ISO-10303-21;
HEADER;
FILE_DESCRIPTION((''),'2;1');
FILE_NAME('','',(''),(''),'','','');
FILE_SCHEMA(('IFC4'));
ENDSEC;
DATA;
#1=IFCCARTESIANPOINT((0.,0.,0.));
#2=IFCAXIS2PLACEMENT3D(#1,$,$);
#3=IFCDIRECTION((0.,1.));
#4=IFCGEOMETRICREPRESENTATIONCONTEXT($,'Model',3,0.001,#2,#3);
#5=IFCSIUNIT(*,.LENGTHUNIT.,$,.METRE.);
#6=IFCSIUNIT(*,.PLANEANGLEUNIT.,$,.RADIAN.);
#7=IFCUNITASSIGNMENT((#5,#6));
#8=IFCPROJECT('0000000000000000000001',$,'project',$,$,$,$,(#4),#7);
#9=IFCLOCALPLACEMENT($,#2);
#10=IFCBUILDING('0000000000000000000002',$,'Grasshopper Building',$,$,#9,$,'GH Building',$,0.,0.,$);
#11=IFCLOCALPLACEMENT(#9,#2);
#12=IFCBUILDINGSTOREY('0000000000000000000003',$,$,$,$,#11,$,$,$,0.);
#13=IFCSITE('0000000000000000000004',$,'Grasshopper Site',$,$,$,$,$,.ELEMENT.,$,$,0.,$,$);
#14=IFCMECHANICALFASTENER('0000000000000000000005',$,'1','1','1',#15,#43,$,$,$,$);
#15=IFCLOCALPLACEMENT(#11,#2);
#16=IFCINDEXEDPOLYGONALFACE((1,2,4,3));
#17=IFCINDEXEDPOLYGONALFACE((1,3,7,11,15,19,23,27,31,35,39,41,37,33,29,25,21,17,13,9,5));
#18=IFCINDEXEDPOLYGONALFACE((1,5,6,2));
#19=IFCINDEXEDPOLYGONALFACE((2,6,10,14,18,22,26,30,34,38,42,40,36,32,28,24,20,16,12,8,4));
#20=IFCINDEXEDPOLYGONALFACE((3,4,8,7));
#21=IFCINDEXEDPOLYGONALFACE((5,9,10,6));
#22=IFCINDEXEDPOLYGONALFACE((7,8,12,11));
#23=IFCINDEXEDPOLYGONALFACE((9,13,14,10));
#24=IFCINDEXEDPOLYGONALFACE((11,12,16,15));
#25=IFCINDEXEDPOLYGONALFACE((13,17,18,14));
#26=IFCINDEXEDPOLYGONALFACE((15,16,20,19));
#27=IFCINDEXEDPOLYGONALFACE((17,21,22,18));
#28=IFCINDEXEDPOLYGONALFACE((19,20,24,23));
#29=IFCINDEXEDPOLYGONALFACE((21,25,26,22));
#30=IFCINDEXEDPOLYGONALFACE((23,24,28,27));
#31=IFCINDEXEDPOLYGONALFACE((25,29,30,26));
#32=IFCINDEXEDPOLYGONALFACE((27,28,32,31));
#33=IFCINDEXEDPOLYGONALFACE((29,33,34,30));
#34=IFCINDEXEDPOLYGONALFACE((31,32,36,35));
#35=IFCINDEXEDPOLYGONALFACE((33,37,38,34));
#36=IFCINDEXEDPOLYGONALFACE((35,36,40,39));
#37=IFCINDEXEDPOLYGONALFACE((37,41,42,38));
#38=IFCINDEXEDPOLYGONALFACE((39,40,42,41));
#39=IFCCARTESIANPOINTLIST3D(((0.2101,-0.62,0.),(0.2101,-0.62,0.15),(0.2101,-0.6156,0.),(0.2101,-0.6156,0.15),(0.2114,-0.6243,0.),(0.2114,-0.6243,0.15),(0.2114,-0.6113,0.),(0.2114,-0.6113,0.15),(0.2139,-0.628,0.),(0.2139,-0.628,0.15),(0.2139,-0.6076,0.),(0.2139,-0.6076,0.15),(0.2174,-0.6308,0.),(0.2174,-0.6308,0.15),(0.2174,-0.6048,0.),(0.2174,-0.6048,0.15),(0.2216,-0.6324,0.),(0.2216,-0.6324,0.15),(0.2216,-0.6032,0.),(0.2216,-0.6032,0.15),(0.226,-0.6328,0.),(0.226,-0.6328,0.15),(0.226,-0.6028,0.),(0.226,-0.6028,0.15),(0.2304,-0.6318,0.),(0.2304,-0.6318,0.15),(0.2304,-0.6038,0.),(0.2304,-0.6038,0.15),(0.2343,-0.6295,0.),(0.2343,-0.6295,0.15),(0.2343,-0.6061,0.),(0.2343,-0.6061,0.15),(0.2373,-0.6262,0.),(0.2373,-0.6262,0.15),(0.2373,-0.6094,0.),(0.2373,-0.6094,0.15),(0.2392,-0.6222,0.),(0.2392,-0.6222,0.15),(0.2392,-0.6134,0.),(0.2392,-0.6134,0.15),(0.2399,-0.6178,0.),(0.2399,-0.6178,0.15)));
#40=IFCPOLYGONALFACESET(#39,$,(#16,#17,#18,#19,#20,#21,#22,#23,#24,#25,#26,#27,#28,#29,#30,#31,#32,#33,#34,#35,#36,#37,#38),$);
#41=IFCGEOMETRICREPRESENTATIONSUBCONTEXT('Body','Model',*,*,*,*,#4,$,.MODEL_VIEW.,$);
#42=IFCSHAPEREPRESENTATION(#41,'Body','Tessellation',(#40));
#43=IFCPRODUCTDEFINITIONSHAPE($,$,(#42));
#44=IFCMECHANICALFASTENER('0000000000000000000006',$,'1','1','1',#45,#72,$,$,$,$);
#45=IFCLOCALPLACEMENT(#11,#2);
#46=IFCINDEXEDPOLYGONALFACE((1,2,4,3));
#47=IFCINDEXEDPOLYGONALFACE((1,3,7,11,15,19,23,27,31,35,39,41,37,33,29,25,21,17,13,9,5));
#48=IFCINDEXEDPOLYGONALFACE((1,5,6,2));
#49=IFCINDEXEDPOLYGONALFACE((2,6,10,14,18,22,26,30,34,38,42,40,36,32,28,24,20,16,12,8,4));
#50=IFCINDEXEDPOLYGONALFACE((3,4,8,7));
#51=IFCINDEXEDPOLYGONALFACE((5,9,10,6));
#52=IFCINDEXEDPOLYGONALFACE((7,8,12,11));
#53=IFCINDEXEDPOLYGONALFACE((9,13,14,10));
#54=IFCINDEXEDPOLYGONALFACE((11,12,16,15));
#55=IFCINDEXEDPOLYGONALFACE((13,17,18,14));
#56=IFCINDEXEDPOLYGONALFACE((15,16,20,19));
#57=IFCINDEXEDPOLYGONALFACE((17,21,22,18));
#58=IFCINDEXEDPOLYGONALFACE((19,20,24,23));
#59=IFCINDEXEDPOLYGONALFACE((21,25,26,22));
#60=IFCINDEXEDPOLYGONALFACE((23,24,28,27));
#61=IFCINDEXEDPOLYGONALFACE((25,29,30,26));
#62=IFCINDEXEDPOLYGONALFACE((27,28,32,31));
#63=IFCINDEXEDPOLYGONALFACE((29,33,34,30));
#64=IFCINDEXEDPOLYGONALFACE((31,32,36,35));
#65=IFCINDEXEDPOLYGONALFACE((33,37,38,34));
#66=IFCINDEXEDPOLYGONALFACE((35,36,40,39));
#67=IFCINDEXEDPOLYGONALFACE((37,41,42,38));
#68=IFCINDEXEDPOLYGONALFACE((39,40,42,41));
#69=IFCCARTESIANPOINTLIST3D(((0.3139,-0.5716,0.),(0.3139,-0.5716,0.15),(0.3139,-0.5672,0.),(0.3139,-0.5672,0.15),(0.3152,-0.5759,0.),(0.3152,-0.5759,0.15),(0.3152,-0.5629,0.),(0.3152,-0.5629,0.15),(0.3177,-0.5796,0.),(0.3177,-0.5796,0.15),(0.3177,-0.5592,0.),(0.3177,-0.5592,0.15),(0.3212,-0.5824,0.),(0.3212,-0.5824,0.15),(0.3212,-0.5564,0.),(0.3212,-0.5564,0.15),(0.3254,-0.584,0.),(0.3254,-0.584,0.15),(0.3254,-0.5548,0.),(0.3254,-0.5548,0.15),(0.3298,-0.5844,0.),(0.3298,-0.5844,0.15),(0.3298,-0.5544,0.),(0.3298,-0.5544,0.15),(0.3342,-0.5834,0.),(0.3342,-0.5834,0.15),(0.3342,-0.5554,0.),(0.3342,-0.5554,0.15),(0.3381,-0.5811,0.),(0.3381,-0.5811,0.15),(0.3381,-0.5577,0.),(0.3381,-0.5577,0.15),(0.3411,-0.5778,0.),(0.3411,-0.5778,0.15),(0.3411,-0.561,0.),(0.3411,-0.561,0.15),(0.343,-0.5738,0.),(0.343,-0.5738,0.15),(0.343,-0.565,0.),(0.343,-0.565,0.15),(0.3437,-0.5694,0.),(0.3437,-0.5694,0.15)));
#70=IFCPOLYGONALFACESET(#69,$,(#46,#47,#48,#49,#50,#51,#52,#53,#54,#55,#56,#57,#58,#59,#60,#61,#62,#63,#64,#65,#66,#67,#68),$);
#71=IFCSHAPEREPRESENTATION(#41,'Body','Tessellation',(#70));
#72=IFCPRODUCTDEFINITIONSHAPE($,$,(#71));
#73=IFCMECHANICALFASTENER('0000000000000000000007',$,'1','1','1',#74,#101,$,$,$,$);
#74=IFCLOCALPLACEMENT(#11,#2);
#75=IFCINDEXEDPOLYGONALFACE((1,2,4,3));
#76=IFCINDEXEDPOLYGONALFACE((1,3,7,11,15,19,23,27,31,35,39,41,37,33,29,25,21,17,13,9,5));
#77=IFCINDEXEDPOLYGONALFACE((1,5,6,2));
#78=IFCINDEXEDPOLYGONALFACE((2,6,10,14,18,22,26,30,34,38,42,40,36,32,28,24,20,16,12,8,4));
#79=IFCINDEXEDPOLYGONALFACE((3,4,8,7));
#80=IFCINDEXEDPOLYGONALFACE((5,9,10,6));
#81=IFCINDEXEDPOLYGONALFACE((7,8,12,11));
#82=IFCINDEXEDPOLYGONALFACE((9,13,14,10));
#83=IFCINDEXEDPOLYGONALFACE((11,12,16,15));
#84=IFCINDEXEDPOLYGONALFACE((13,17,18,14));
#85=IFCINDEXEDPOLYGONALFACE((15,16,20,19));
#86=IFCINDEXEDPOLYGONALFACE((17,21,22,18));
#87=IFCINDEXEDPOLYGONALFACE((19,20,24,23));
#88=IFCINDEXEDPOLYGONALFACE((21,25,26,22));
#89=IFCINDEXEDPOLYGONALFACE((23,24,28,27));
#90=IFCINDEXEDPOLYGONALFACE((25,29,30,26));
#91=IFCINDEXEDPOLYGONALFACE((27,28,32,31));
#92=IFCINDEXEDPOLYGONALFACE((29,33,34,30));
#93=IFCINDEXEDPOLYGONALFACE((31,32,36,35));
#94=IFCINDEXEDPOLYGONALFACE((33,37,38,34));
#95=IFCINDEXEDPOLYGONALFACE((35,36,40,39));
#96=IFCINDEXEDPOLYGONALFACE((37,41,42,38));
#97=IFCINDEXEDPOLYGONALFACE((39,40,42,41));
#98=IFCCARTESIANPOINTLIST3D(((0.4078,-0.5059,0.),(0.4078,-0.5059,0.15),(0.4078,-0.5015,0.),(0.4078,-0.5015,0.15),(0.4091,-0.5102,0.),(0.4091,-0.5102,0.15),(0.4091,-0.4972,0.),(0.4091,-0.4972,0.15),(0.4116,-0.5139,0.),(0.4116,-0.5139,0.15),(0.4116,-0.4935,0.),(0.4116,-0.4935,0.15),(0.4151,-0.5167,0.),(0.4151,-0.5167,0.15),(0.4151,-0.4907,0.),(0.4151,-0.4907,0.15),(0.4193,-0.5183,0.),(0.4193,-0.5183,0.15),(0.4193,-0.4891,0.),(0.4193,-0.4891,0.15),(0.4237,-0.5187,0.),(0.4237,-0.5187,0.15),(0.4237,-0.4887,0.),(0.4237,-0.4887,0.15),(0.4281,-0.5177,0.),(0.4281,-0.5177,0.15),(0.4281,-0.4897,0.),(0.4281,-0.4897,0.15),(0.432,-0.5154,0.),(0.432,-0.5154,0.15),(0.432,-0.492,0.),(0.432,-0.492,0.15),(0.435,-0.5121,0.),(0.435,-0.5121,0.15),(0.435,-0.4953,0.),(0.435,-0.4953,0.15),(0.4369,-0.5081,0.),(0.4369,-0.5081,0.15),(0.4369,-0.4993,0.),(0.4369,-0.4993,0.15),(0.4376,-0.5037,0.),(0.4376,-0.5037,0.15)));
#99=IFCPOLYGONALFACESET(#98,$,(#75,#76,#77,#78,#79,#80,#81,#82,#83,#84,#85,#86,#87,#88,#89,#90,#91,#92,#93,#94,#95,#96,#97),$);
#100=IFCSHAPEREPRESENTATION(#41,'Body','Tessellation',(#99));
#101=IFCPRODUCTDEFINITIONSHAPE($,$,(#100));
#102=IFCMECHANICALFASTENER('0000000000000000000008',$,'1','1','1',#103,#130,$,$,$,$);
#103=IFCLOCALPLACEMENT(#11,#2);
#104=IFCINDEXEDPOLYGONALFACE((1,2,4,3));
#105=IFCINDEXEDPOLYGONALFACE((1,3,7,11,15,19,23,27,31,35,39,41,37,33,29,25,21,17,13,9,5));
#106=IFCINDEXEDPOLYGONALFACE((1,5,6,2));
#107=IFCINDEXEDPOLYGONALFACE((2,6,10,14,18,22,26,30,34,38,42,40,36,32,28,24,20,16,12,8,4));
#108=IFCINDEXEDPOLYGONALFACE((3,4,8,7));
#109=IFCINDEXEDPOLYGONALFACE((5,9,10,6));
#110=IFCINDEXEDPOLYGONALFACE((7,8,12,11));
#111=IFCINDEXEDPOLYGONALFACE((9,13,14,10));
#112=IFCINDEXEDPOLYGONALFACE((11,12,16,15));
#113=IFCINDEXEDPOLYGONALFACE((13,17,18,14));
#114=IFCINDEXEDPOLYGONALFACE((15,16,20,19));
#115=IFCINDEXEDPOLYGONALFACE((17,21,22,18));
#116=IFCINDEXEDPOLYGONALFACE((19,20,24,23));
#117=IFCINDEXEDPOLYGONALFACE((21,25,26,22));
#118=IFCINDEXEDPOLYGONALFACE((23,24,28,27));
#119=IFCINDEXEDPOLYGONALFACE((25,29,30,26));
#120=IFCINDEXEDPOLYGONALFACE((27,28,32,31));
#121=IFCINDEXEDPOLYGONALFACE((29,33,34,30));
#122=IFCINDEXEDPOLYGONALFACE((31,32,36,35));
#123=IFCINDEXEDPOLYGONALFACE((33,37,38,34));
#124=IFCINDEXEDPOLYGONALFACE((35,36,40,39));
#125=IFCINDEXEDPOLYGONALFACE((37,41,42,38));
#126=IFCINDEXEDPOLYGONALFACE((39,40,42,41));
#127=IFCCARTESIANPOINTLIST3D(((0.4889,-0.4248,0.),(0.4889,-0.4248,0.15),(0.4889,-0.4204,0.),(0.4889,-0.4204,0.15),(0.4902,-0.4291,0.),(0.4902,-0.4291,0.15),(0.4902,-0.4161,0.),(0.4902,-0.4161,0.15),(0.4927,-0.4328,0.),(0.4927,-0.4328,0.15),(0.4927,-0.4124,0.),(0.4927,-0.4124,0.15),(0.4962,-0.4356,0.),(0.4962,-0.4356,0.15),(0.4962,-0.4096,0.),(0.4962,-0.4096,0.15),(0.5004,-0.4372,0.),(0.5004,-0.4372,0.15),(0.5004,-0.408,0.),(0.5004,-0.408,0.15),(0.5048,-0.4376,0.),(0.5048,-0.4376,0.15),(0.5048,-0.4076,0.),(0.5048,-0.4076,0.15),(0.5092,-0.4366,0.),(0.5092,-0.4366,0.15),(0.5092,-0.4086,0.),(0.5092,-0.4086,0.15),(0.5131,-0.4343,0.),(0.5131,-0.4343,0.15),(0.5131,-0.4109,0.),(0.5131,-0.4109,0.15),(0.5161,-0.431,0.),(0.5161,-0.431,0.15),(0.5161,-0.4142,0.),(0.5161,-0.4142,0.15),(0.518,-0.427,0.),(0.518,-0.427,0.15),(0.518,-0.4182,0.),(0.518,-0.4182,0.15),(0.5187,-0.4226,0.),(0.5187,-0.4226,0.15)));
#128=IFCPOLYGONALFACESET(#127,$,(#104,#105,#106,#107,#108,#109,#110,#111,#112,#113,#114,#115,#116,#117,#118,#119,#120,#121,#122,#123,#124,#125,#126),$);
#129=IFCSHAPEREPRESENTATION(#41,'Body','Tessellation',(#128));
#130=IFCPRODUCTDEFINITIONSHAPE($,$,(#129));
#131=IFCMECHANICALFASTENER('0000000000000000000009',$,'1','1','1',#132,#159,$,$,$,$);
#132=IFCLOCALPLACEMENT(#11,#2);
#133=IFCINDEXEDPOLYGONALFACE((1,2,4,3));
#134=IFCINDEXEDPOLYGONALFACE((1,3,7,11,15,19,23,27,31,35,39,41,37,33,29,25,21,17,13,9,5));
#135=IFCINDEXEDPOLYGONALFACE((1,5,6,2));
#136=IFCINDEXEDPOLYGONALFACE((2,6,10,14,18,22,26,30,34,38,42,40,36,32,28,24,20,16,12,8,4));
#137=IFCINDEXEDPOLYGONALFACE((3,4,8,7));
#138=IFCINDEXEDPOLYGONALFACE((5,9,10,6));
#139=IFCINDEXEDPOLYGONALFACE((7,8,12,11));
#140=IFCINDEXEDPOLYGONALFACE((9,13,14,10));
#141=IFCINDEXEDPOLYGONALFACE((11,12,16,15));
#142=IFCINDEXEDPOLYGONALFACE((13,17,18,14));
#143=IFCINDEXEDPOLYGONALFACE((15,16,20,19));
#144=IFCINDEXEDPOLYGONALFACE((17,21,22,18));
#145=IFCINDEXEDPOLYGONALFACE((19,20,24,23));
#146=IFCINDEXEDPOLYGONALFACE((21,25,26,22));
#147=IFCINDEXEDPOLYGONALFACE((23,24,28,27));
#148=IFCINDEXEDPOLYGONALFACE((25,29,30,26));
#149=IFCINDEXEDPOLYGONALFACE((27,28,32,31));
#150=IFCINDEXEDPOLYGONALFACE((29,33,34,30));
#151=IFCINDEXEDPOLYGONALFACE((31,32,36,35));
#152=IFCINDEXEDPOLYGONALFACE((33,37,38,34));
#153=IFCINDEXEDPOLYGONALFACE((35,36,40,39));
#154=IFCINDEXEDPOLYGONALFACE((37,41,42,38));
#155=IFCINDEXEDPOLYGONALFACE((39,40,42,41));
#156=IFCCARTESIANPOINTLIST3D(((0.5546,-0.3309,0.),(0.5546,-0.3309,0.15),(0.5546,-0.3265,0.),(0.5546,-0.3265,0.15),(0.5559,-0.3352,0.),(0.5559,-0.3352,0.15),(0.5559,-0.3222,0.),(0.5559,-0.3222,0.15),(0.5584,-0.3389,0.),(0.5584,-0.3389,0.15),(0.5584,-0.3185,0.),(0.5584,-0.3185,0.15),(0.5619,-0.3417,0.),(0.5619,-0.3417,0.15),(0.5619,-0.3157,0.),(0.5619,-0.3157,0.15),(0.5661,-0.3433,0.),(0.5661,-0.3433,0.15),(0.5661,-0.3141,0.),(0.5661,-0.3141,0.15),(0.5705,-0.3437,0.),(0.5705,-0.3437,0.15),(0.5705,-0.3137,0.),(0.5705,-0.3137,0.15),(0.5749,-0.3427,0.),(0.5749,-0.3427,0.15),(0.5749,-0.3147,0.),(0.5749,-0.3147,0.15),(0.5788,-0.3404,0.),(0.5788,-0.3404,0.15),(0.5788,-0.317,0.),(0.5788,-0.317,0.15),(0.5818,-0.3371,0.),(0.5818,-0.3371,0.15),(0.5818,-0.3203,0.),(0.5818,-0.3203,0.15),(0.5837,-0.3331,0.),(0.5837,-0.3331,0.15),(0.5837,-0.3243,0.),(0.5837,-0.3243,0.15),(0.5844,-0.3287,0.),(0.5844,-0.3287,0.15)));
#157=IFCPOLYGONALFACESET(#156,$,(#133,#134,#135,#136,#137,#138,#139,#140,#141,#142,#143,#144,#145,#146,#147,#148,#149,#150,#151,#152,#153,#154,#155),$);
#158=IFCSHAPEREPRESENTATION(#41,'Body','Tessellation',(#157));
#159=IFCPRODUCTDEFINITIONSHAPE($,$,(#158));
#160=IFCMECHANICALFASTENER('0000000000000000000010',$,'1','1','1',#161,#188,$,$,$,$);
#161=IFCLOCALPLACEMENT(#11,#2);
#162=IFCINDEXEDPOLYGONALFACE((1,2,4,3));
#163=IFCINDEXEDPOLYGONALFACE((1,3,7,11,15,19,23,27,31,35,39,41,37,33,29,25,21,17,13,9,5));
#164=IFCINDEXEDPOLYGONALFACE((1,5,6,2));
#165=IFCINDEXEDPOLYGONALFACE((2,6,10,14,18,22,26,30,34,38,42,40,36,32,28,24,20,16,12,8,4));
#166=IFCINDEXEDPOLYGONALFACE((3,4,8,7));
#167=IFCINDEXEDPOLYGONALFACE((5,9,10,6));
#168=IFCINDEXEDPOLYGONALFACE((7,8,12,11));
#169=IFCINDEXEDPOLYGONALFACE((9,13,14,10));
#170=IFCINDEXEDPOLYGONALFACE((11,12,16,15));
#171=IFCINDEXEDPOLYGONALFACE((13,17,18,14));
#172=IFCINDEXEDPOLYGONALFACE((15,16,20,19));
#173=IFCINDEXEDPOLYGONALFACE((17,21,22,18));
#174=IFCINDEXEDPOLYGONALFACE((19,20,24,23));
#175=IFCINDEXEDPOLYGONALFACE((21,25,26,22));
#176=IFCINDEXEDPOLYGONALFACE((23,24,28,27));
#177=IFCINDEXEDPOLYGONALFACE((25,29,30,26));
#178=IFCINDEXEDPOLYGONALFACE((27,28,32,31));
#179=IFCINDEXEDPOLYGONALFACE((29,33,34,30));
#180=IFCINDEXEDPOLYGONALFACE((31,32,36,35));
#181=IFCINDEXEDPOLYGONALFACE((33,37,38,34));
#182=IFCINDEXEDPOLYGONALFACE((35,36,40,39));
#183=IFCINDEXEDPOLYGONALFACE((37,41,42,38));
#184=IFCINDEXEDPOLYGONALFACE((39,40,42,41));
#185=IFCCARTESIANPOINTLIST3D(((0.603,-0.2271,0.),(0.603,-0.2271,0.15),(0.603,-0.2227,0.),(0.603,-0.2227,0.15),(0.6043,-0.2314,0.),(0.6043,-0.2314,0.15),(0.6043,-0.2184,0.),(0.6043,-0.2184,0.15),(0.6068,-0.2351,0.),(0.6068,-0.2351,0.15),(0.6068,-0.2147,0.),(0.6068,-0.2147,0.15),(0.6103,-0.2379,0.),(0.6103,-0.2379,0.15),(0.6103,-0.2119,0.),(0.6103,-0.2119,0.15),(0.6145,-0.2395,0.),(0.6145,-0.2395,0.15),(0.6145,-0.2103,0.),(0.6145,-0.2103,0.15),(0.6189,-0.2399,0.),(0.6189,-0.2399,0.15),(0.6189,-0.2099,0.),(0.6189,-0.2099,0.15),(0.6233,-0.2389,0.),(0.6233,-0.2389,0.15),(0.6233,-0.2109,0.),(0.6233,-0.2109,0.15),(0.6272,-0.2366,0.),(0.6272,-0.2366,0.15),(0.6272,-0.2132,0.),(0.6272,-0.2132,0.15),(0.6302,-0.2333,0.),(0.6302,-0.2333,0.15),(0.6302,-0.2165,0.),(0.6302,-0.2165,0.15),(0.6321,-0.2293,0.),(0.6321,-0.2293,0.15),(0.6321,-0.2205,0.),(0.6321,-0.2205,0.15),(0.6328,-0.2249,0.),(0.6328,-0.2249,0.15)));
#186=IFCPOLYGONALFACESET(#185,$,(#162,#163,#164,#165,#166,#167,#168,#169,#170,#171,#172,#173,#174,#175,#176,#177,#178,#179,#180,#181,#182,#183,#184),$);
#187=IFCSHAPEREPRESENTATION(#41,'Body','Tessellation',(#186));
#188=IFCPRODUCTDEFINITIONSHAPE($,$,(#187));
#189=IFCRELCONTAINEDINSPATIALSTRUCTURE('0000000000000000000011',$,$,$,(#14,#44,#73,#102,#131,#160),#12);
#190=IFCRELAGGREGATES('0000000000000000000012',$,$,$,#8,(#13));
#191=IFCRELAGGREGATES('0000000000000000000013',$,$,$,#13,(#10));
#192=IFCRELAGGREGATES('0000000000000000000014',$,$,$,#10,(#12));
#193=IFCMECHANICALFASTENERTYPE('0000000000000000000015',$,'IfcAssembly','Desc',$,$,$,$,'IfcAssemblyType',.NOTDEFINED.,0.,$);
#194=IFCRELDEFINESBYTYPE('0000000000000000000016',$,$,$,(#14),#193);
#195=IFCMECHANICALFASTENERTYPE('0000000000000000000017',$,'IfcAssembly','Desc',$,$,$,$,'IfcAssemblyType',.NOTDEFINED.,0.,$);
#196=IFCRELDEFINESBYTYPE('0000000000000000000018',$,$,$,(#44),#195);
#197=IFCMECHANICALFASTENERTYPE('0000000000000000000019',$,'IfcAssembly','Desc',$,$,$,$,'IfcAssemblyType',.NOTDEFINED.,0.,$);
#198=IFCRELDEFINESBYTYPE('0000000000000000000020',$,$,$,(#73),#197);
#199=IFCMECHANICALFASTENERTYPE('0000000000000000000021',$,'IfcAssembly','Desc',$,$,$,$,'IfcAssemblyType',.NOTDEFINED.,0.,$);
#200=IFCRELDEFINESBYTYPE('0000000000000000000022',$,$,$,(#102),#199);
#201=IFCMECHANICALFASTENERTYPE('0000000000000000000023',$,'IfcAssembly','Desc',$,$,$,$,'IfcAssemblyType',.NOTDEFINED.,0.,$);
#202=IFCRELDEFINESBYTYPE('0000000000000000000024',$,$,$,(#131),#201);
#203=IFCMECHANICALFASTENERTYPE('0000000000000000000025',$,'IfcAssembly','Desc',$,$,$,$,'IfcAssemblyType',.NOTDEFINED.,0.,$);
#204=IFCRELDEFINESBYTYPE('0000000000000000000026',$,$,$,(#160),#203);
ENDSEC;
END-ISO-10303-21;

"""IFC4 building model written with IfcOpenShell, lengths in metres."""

from ifc_helpers import new_model, si_unit, direction, frame, origin, place, context, subcontext, project, spatial, circle, extrude, source, transform, mapped, type_object, type_shapes, element, save


model = new_model("IFC4")

# Units and contexts
model_context = context("Model", 3, precision=0.001, world=origin(), true_north=direction((0.0, 1.0)))
body_context = subcontext(model_context, "Body", "Model", "MODEL_VIEW")
ifc_project = project(units=[si_unit("LENGTHUNIT", "METRE"), si_unit("PLANEANGLEUNIT", "RADIAN")], contexts=[model_context])

# Site, building, storey
site = spatial("IfcSite", under=ifc_project, Name="Grasshopper Site", CompositionType="ELEMENT", RefElevation=0.0)
building_placement = place(None, origin())
building = spatial("IfcBuilding", under=site, at=building_placement, Name="Grasshopper Building", LongName="GH Building", ElevationOfRefHeight=0.0, ElevationOfTerrain=0.0)
storey_placement = place(building_placement, origin())
storey = spatial("IfcBuildingStorey", under=building, at=storey_placement, Elevation=0.0)

# Mechanical fasteners
mechanical_fastener_type_1 = type_object("IfcMechanicalFastenerType", Name="IfcAssembly", Description="Desc", ElementType="IfcAssemblyType", NominalDiameter=0.0)
shared_shape_1 = source(origin(), body_context, "Body", "SweptSolid", [
    extrude(circle(Radius=0.015), frame((0.2249, -0.6178, 0.0)), (0.0, 0.0, 1.0), 0.15),
])
type_shapes(mechanical_fastener_type_1, [shared_shape_1])
mechanical_fastener_1_placement = place(storey_placement, origin())
element("IfcMechanicalFastener", 1, at=mechanical_fastener_1_placement, inside=storey, type_object=mechanical_fastener_type_1, Name="1", Description="1", ObjectType="1", context=body_context, shape_type="MappedRepresentation", body=[
    mapped(shared_shape_1, transform((0.0, 0.0, 0.0), scale=1.0)),
])
mechanical_fastener_type_2 = type_object("IfcMechanicalFastenerType", Name="IfcAssembly", Description="Desc", ElementType="IfcAssemblyType", NominalDiameter=0.0)
shared_shape_2 = source(origin(), body_context, "Body", "SweptSolid", [
    extrude(circle(Radius=0.015), frame((0.3287, -0.5694, 0.0)), (0.0, 0.0, 1.0), 0.15),
])
type_shapes(mechanical_fastener_type_2, [shared_shape_2])
mechanical_fastener_2_placement = place(storey_placement, origin())
element("IfcMechanicalFastener", 2, at=mechanical_fastener_2_placement, inside=storey, type_object=mechanical_fastener_type_2, Name="1", Description="1", ObjectType="1", context=body_context, shape_type="MappedRepresentation", body=[
    mapped(shared_shape_2, transform((0.0, 0.0, 0.0), scale=1.0)),
])
mechanical_fastener_type_3 = type_object("IfcMechanicalFastenerType", Name="IfcAssembly", Description="Desc", ElementType="IfcAssemblyType", NominalDiameter=0.0)
shared_shape_3 = source(origin(), body_context, "Body", "SweptSolid", [
    extrude(circle(Radius=0.015), frame((0.4226, -0.5037, 0.0)), (0.0, 0.0, 1.0), 0.15),
])
type_shapes(mechanical_fastener_type_3, [shared_shape_3])
mechanical_fastener_3_placement = place(storey_placement, origin())
element("IfcMechanicalFastener", 3, at=mechanical_fastener_3_placement, inside=storey, type_object=mechanical_fastener_type_3, Name="1", Description="1", ObjectType="1", context=body_context, shape_type="MappedRepresentation", body=[
    mapped(shared_shape_3, transform((0.0, 0.0, 0.0), scale=1.0)),
])
mechanical_fastener_type_4 = type_object("IfcMechanicalFastenerType", Name="IfcAssembly", Description="Desc", ElementType="IfcAssemblyType", NominalDiameter=0.0)
shared_shape_4 = source(origin(), body_context, "Body", "SweptSolid", [
    extrude(circle(Radius=0.015), frame((0.5037, -0.4226, 0.0)), (0.0, 0.0, 1.0), 0.15),
])
type_shapes(mechanical_fastener_type_4, [shared_shape_4])
mechanical_fastener_4_placement = place(storey_placement, origin())
element("IfcMechanicalFastener", 4, at=mechanical_fastener_4_placement, inside=storey, type_object=mechanical_fastener_type_4, Name="1", Description="1", ObjectType="1", context=body_context, shape_type="MappedRepresentation", body=[
    mapped(shared_shape_4, transform((0.0, 0.0, 0.0), scale=1.0)),
])
mechanical_fastener_type_5 = type_object("IfcMechanicalFastenerType", Name="IfcAssembly", Description="Desc", ElementType="IfcAssemblyType", NominalDiameter=0.0)
shared_shape_5 = source(origin(), body_context, "Body", "SweptSolid", [
    extrude(circle(Radius=0.015), frame((0.5694, -0.3287, 0.0)), (0.0, 0.0, 1.0), 0.15),
])
type_shapes(mechanical_fastener_type_5, [shared_shape_5])
mechanical_fastener_5_placement = place(storey_placement, origin())
element("IfcMechanicalFastener", 5, at=mechanical_fastener_5_placement, inside=storey, type_object=mechanical_fastener_type_5, Name="1", Description="1", ObjectType="1", context=body_context, shape_type="MappedRepresentation", body=[
    mapped(shared_shape_5, transform((0.0, 0.0, 0.0), scale=1.0)),
])
mechanical_fastener_type_6 = type_object("IfcMechanicalFastenerType", Name="IfcAssembly", Description="Desc", ElementType="IfcAssemblyType", NominalDiameter=0.0)
shared_shape_6 = source(origin(), body_context, "Body", "SweptSolid", [
    extrude(circle(Radius=0.015), frame((0.6178, -0.2249, 0.0)), (0.0, 0.0, 1.0), 0.15),
])
type_shapes(mechanical_fastener_type_6, [shared_shape_6])
mechanical_fastener_6_placement = place(storey_placement, origin())
element("IfcMechanicalFastener", 6, at=mechanical_fastener_6_placement, inside=storey, type_object=mechanical_fastener_type_6, Name="1", Description="1", ObjectType="1", context=body_context, shape_type="MappedRepresentation", body=[
    mapped(shared_shape_6, transform((0.0, 0.0, 0.0), scale=1.0)),
])

save(model, "model.ifc")
